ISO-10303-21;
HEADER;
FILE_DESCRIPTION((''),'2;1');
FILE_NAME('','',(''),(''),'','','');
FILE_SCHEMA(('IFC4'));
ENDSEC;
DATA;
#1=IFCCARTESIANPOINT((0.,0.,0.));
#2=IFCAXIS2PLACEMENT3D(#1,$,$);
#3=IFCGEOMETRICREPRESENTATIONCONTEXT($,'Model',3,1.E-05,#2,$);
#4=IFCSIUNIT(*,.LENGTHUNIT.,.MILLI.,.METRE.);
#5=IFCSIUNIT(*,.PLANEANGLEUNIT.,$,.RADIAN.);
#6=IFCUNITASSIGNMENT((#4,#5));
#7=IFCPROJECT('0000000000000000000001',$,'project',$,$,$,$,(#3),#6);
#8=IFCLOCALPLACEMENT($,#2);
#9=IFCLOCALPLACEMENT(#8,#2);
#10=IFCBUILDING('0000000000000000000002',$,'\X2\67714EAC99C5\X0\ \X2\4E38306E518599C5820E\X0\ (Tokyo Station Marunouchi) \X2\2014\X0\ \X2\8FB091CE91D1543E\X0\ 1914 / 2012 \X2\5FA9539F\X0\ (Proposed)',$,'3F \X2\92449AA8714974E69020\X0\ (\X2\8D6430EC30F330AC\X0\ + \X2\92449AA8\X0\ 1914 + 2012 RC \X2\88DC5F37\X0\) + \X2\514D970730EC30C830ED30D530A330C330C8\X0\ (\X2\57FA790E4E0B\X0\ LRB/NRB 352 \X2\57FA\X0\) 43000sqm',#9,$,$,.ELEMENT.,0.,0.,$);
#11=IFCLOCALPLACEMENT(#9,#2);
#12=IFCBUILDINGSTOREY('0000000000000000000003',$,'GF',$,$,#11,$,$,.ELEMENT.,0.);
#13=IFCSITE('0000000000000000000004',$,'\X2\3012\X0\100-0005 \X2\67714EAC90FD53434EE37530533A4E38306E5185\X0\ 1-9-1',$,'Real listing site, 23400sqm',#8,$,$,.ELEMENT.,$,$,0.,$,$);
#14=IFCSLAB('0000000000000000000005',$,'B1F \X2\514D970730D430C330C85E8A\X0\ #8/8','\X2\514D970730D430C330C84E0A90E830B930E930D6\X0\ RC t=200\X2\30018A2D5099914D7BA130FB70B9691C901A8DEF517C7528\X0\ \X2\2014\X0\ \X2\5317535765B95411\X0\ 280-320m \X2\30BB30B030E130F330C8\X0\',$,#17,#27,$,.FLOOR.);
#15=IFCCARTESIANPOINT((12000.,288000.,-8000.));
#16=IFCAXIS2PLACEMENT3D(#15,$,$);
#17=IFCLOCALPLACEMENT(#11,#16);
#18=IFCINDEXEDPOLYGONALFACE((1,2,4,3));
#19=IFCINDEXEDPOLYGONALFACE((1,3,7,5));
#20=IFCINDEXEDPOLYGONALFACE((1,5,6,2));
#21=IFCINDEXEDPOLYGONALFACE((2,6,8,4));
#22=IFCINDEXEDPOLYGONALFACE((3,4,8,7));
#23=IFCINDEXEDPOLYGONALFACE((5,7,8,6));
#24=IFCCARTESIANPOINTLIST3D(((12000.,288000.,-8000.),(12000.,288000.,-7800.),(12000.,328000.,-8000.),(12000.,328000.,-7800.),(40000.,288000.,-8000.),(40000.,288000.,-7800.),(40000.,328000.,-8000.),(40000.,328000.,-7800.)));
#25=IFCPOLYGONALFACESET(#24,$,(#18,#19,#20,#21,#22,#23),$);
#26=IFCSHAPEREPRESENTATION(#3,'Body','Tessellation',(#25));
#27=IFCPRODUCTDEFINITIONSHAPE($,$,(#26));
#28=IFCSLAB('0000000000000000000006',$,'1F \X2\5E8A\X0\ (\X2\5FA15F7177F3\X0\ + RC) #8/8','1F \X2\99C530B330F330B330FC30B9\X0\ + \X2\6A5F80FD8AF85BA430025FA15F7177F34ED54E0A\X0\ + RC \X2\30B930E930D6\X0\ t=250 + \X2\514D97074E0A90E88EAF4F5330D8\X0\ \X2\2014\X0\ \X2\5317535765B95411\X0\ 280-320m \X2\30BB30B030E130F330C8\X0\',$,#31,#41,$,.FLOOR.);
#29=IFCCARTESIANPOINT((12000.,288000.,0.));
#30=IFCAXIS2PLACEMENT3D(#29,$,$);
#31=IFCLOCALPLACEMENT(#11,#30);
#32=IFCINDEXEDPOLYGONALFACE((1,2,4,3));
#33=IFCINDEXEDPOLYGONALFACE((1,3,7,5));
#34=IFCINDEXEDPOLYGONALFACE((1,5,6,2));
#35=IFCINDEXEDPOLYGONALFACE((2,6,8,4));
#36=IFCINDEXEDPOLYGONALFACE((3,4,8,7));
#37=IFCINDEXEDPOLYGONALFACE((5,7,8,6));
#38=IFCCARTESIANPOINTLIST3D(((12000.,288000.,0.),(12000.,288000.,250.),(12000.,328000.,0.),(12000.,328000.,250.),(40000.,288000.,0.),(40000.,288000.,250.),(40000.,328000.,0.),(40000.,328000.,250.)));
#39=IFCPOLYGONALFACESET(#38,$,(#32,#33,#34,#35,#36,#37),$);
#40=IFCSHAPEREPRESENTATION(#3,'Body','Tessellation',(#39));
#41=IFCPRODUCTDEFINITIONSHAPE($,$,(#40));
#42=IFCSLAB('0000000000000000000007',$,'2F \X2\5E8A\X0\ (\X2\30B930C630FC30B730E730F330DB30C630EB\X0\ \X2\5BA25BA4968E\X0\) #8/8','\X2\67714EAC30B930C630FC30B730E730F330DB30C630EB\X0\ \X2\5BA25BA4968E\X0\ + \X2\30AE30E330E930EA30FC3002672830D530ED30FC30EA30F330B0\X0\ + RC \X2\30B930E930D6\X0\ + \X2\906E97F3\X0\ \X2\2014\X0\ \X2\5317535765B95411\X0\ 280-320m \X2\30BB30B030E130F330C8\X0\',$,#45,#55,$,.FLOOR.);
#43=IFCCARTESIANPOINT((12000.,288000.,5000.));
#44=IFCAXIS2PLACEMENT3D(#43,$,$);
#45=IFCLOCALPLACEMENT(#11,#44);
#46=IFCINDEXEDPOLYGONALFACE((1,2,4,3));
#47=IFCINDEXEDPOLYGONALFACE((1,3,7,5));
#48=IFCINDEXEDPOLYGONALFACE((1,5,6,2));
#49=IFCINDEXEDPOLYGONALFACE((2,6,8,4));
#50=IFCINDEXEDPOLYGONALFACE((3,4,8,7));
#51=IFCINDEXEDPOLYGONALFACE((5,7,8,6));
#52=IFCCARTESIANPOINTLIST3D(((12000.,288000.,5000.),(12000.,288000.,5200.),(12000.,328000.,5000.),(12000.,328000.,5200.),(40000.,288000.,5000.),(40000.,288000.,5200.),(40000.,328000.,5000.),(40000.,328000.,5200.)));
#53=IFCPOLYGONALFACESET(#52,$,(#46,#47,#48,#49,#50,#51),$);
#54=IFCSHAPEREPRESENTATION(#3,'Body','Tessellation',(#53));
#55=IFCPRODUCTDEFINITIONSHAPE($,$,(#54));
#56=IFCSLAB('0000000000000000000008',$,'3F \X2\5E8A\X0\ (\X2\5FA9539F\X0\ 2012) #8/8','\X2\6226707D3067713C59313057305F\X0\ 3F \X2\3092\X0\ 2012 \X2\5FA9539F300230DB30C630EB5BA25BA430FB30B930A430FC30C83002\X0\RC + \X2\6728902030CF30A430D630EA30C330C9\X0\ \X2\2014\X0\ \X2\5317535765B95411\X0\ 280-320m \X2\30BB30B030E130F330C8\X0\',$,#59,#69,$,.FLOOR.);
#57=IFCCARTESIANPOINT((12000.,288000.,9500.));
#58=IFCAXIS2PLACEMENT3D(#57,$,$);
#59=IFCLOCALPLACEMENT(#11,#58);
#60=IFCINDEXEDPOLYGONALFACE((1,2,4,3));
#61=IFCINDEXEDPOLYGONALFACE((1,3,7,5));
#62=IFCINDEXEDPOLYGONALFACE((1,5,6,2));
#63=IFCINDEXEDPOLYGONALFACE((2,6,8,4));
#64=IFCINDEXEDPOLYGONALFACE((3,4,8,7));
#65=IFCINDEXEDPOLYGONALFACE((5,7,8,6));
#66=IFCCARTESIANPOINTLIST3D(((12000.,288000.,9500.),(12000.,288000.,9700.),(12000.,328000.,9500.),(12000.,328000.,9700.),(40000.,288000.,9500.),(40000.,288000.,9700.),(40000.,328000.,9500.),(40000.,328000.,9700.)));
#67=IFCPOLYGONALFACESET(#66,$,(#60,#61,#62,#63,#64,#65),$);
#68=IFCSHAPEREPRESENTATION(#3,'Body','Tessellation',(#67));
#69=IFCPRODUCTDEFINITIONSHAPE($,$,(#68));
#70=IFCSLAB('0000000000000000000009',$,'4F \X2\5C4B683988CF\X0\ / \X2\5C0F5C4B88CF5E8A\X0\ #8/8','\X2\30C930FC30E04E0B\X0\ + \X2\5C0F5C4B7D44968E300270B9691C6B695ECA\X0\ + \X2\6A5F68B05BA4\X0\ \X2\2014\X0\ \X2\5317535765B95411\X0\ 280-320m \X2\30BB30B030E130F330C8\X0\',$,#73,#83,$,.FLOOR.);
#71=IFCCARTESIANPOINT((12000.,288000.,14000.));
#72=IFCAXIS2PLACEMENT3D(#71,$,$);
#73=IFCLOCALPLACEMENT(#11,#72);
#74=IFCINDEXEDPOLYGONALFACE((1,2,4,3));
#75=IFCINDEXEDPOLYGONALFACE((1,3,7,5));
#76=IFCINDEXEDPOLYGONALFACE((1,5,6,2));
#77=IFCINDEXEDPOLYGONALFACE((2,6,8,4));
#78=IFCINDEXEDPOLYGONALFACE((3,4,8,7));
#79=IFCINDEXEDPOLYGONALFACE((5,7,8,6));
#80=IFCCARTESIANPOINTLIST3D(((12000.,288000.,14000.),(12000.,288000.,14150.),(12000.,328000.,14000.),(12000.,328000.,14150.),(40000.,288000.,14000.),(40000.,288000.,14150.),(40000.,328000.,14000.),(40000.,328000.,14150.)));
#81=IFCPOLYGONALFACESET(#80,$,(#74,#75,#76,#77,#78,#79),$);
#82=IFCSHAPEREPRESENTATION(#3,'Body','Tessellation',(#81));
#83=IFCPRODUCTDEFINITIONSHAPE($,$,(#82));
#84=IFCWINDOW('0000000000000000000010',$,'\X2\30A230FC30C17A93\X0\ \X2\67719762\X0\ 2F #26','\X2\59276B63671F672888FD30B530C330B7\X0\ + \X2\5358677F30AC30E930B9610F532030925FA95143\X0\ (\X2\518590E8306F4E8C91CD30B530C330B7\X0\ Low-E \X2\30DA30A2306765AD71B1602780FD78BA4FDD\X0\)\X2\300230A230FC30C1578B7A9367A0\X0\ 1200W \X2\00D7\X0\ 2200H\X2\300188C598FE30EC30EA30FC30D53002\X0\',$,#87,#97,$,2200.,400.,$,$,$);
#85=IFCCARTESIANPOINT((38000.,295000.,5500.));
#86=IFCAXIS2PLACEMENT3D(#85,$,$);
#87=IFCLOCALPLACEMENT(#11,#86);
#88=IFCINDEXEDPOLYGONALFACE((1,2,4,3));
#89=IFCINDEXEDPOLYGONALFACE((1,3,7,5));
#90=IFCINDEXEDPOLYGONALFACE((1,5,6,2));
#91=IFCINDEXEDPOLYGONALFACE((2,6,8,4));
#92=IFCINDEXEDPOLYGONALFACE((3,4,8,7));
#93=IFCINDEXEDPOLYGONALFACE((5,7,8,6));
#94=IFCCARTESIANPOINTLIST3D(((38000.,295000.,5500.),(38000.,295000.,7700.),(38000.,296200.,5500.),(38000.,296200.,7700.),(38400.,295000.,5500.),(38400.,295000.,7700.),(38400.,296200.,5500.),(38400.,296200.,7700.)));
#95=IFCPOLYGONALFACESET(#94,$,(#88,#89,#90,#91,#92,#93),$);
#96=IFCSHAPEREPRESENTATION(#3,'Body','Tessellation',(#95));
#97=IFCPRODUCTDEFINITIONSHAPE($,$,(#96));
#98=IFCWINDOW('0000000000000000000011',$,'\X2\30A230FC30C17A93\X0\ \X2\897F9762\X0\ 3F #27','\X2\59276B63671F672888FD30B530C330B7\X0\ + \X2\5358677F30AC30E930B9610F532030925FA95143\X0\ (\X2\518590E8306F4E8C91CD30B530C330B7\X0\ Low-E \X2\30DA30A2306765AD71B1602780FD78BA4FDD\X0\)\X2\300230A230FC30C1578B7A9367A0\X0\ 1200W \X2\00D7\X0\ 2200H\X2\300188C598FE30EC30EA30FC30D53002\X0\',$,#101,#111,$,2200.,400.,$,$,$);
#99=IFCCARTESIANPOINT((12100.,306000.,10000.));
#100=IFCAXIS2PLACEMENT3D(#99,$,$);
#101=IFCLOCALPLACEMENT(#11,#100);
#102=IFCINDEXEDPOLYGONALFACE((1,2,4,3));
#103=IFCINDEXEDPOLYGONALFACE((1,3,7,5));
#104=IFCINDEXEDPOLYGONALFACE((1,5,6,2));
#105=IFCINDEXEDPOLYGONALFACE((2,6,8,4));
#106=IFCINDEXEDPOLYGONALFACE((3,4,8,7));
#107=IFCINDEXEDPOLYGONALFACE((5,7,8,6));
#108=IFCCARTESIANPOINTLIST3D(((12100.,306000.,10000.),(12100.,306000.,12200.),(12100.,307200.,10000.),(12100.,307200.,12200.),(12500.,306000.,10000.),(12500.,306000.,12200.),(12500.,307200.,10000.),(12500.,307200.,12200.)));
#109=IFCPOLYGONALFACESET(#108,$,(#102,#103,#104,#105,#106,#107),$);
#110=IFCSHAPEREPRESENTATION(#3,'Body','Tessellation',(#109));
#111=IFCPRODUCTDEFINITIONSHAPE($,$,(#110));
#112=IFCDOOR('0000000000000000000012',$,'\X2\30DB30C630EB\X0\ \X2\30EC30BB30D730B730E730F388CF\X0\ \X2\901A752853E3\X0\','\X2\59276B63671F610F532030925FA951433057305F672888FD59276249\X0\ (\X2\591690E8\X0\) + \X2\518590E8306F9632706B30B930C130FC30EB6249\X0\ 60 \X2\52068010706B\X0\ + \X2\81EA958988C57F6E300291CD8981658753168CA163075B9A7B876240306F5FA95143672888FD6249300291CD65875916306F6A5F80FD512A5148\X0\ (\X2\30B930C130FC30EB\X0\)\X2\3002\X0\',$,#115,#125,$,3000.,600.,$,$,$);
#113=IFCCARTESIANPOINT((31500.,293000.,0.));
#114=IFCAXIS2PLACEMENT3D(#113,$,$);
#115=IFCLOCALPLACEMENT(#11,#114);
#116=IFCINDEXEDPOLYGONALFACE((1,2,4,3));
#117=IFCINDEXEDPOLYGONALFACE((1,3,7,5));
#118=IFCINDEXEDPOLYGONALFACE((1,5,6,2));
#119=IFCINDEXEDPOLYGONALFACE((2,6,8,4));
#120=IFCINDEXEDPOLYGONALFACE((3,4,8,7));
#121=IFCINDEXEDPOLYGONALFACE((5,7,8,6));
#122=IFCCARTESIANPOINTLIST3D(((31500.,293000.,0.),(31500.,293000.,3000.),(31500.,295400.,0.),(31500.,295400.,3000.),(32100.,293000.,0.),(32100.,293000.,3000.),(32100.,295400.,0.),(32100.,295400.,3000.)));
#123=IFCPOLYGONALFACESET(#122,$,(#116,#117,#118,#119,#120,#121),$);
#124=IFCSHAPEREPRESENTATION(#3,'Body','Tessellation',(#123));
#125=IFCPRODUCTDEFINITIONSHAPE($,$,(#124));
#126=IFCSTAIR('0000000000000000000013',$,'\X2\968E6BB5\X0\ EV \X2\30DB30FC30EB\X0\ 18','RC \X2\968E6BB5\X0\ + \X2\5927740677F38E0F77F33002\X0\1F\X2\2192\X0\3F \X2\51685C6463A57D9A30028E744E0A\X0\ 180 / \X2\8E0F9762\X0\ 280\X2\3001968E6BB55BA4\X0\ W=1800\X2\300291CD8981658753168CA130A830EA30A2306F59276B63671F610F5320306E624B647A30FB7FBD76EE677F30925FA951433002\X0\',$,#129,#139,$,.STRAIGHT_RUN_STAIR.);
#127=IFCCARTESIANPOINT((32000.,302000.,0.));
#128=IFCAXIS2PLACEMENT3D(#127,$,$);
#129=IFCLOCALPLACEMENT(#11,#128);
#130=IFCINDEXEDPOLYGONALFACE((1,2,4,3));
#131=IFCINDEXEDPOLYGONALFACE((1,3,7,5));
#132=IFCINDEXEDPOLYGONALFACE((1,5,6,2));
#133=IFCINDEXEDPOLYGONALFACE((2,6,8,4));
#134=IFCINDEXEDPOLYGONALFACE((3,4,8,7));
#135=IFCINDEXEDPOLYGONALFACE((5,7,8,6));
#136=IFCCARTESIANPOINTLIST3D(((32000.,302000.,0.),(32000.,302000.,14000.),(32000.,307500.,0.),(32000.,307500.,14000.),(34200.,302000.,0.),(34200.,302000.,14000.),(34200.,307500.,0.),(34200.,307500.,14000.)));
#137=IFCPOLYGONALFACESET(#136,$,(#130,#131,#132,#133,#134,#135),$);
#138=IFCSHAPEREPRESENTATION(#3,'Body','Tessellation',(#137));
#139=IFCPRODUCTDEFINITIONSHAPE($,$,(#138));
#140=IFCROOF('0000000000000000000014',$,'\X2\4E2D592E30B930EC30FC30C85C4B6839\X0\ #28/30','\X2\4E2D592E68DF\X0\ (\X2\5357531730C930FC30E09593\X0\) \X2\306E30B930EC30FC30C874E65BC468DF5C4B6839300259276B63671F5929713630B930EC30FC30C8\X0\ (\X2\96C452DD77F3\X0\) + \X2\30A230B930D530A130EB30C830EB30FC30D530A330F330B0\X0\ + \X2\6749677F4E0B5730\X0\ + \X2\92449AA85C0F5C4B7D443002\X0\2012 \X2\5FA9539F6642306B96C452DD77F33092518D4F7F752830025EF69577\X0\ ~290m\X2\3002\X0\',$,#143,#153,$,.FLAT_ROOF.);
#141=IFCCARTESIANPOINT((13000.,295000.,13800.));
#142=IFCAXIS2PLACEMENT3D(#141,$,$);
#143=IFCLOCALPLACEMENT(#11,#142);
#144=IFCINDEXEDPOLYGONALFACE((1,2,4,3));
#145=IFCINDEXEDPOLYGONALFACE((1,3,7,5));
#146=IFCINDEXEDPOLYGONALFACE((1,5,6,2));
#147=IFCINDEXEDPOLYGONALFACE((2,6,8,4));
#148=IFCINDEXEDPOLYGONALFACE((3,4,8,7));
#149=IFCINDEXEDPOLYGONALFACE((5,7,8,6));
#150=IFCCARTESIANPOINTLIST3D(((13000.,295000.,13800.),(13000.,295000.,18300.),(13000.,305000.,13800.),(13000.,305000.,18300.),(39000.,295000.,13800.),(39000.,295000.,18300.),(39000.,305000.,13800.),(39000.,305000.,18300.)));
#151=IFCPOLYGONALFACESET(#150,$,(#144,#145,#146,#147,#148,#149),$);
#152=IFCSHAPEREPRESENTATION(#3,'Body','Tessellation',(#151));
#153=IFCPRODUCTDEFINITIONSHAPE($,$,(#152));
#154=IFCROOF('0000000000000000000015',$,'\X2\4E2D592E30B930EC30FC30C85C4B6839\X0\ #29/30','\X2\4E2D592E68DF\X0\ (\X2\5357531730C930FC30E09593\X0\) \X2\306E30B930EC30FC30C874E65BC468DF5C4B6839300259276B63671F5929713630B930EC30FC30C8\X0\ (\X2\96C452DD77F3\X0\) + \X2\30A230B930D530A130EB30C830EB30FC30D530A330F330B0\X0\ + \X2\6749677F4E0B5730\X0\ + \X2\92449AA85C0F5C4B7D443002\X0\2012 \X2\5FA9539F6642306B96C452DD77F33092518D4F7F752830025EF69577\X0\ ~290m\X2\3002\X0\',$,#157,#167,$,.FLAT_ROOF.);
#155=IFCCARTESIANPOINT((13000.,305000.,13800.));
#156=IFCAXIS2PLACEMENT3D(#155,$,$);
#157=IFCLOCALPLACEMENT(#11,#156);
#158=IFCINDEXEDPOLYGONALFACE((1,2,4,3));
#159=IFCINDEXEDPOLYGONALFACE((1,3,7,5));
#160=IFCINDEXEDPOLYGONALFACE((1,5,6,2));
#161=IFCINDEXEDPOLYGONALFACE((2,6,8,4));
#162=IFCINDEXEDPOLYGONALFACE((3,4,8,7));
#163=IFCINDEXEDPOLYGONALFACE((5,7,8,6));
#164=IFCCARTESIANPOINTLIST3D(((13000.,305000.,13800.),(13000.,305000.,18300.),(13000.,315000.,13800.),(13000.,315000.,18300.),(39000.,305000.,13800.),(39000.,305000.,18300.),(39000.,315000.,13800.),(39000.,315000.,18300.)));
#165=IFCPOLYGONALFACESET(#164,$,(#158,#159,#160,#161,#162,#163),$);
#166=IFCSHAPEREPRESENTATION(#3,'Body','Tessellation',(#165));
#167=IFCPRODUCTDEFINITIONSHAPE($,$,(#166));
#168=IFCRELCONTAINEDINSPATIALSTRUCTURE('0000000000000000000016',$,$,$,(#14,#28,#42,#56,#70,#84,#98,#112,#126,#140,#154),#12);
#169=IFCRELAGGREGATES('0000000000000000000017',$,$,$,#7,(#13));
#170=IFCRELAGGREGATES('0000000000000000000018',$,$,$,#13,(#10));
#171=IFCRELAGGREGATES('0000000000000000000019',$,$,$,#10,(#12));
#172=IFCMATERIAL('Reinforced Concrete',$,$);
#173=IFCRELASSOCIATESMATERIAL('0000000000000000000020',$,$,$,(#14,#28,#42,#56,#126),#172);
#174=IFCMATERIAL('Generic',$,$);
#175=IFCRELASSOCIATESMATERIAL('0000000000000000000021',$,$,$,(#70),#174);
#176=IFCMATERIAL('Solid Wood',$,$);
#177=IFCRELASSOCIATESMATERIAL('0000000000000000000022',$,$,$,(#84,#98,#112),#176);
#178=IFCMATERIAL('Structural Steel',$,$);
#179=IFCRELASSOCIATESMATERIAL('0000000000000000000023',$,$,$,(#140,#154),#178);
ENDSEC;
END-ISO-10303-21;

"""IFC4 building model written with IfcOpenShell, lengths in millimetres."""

from ifc_helpers import new_model, si_unit, frame, frame_2d, origin, place, context, project, spatial, rectangle, extrude, material, element, save


model = new_model("IFC4")

# Units and contexts
model_context = context("Model", 3, precision=1e-05, world=origin())
ifc_project = project(units=[si_unit("LENGTHUNIT", "METRE", prefix="MILLI"), si_unit("PLANEANGLEUNIT", "RADIAN")], contexts=[model_context])

# Site, building, storey
site_placement = place(None, origin())
site = spatial("IfcSite", under=ifc_project, at=site_placement, Name="〒100-0005 東京都千代田区丸の内 1-9-1", ObjectType="Real listing site, 23400sqm", CompositionType="ELEMENT", RefElevation=0.0)
building_placement = place(site_placement, origin())
building = spatial("IfcBuilding", under=site, at=building_placement, Name="東京駅 丸の内駅舎 (Tokyo Station Marunouchi) — 辰野金吾 1914 / 2012 復原 (Proposed)", ObjectType="3F 鉄骨煉瓦造 (赤レンガ + 鉄骨 1914 + 2012 RC 補強) + 免震レトロフィット (基礎下 LRB/NRB 352 基) 43000sqm", CompositionType="ELEMENT", ElevationOfRefHeight=0.0, ElevationOfTerrain=0.0)
storey_placement = place(building_placement, origin())
storey = spatial("IfcBuildingStorey", under=building, at=storey_placement, Name="GF", CompositionType="ELEMENT", Elevation=0.0)

# Shared definitions
ifc_material_1 = material(Name="Structural Steel")

# Slabs
ifc_material_2 = material(Name="Reinforced Concrete")
slab_1_placement = place(storey_placement, frame((12000.0, 288000.0, -8000.0)))
element("IfcSlab", 1, at=slab_1_placement, inside=storey, material=ifc_material_2, Name="B1F 免震ピット床 #8/8", Description="免震ピット上部スラブ RC t=200、設備配管・点検通路兼用 — 北南方向 280-320m セグメント", PredefinedType="FLOOR", context=model_context, shape_type="SweptSolid", body=[
    extrude(rectangle(XDim=28000.0, YDim=40000.0, at=frame_2d((14000.0, 20000.0))), frame((12000.0, 288000.0, -8000.0)), (0.0, 0.0, 1.0), 200.0),
])
slab_2_placement = place(storey_placement, frame((12000.0, 288000.0, 0.0)))
element("IfcSlab", 2, at=slab_2_placement, inside=storey, material=ifc_material_2, Name="1F 床 (御影石 + RC) #8/8", Description="1F 駅コンコース + 機能諸室。御影石仕上 + RC スラブ t=250 + 免震上部躯体ヘ — 北南方向 280-320m セグメント", PredefinedType="FLOOR", context=model_context, shape_type="SweptSolid", body=[
    extrude(rectangle(XDim=28000.0, YDim=40000.0, at=frame_2d((14000.0, 20000.0))), frame((12000.0, 288000.0, 0.0)), (0.0, 0.0, 1.0), 250.0),
])
slab_3_placement = place(storey_placement, frame((12000.0, 288000.0, 5000.0)))
element("IfcSlab", 3, at=slab_3_placement, inside=storey, material=ifc_material_2, Name="2F 床 (ステーションホテル 客室階) #8/8", Description="東京ステーションホテル 客室階 + ギャラリー。木フローリング + RC スラブ + 遮音 — 北南方向 280-320m セグメント", PredefinedType="FLOOR", context=model_context, shape_type="SweptSolid", body=[
    extrude(rectangle(XDim=28000.0, YDim=40000.0, at=frame_2d((14000.0, 20000.0))), frame((12000.0, 288000.0, 5000.0)), (0.0, 0.0, 1.0), 200.0),
])
slab_4_placement = place(storey_placement, frame((12000.0, 288000.0, 9500.0)))
element("IfcSlab", 4, at=slab_4_placement, inside=storey, material=ifc_material_2, Name="3F 床 (復原 2012) #8/8", Description="戦災で焼失した 3F を 2012 復原。ホテル客室・スイート。RC + 木造ハイブリッド — 北南方向 280-320m セグメント", PredefinedType="FLOOR", context=model_context, shape_type="SweptSolid", body=[
    extrude(rectangle(XDim=28000.0, YDim=40000.0, at=frame_2d((14000.0, 20000.0))), frame((12000.0, 288000.0, 9500.0)), (0.0, 0.0, 1.0), 200.0),
])
ifc_material_3 = material(Name="Generic")
slab_5_placement = place(storey_placement, frame((12000.0, 288000.0, 14000.0)))
element("IfcSlab", 5, at=slab_5_placement, inside=storey, material=ifc_material_3, Name="4F 屋根裏 / 小屋裏床 #8/8", Description="ドーム下 + 小屋組階。点検歩廊 + 機械室 — 北南方向 280-320m セグメント", PredefinedType="FLOOR", context=model_context, shape_type="SweptSolid", body=[
    extrude(rectangle(XDim=28000.0, YDim=40000.0, at=frame_2d((14000.0, 20000.0))), frame((12000.0, 288000.0, 14000.0)), (0.0, 0.0, 1.0), 150.0),
])

# Windows
ifc_material_4 = material(Name="Solid Wood")
window_1_placement = place(storey_placement, frame((38000.0, 295000.0, 5500.0)))
element("IfcWindow", 6, at=window_1_placement, inside=storey, material=ifc_material_4, Name="アーチ窓 東面 2F #26", Description="大正期木製サッシ + 単板ガラス意匠を復元 (内部は二重サッシ Low-E ペアで断熱性能確保)。アーチ型窓枠 1200W × 2200H、装飾レリーフ。", OverallHeight=2200.0, OverallWidth=400.0, context=model_context, shape_type="SweptSolid", body=[
    extrude(rectangle(XDim=400.0, YDim=1200.0, at=frame_2d((200.0, 600.0))), frame((38000.0, 295000.0, 5500.0)), (0.0, 0.0, 1.0), 2200.0),
])
window_2_placement = place(storey_placement, frame((12100.0, 306000.0, 10000.0)))
element("IfcWindow", 7, at=window_2_placement, inside=storey, material=ifc_material_4, Name="アーチ窓 西面 3F #27", Description="大正期木製サッシ + 単板ガラス意匠を復元 (内部は二重サッシ Low-E ペアで断熱性能確保)。アーチ型窓枠 1200W × 2200H、装飾レリーフ。", OverallHeight=2200.0, OverallWidth=400.0, context=model_context, shape_type="SweptSolid", body=[
    extrude(rectangle(XDim=400.0, YDim=1200.0, at=frame_2d((200.0, 600.0))), frame((12100.0, 306000.0, 10000.0)), (0.0, 0.0, 1.0), 2200.0),
])

# Door
door_placement = place(storey_placement, frame((31500.0, 293000.0, 0.0)))
element("IfcDoor", 8, at=door_placement, inside=storey, material=ifc_material_4, Name="ホテル レセプション裏 通用口", Description="大正期意匠を復元した木製大扉 (外部) + 内部は防火スチール扉 60 分耐火 + 自閉装置。重要文化財指定箇所は復元木製扉。重文外は機能優先 (スチール)。", OverallHeight=3000.0, OverallWidth=600.0, context=model_context, shape_type="SweptSolid", body=[
    extrude(rectangle(XDim=600.0, YDim=2400.0, at=frame_2d((300.0, 1200.0))), frame((31500.0, 293000.0, 0.0)), (0.0, 0.0, 1.0), 3000.0),
])

# Stair
stair_placement = place(storey_placement, frame((32000.0, 302000.0, 0.0)))
element("IfcStair", 9, at=stair_placement, inside=storey, material=ifc_material_2, Name="階段 EV ホール 18", Description="RC 階段 + 大理石踏石。1F→3F 全層接続。蹴上 180 / 踏面 280、階段室 W=1800。重要文化財エリアは大正期意匠の手摺・羽目板を復元。", PredefinedType="STRAIGHT_RUN_STAIR", context=model_context, shape_type="SweptSolid", body=[
    extrude(rectangle(XDim=2200.0, YDim=5500.0, at=frame_2d((1100.0, 2750.0))), frame((32000.0, 302000.0, 0.0)), (0.0, 0.0, 1.0), 14000.0),
])

# Roofs
roof_1_placement = place(storey_placement, frame((13000.0, 295000.0, 13800.0)))
element("IfcRoof", 10, at=roof_1_placement, inside=storey, material=ifc_material_1, Name="中央スレート屋根 #28/30", Description="中央棟 (南北ドーム間) のスレート瓦寄棟屋根。大正期天然スレート (雄勝石) + アスファルトルーフィング + 杉板下地 + 鉄骨小屋組。2012 復原時に雄勝石を再使用。延長 ~290m。", PredefinedType="FLAT_ROOF", context=model_context, shape_type="SweptSolid", body=[
    extrude(rectangle(XDim=26000.0, YDim=10000.0, at=frame_2d((13000.0, 5000.0))), frame((13000.0, 295000.0, 13800.0)), (0.0, 0.0, 1.0), 4500.0),
])
roof_2_placement = place(storey_placement, frame((13000.0, 305000.0, 13800.0)))
element("IfcRoof", 11, at=roof_2_placement, inside=storey, material=ifc_material_1, Name="中央スレート屋根 #29/30", Description="中央棟 (南北ドーム間) のスレート瓦寄棟屋根。大正期天然スレート (雄勝石) + アスファルトルーフィング + 杉板下地 + 鉄骨小屋組。2012 復原時に雄勝石を再使用。延長 ~290m。", PredefinedType="FLAT_ROOF", context=model_context, shape_type="SweptSolid", body=[
    extrude(rectangle(XDim=26000.0, YDim=10000.0, at=frame_2d((13000.0, 5000.0))), frame((13000.0, 305000.0, 13800.0)), (0.0, 0.0, 1.0), 4500.0),
])

save(model, "model.ifc")
